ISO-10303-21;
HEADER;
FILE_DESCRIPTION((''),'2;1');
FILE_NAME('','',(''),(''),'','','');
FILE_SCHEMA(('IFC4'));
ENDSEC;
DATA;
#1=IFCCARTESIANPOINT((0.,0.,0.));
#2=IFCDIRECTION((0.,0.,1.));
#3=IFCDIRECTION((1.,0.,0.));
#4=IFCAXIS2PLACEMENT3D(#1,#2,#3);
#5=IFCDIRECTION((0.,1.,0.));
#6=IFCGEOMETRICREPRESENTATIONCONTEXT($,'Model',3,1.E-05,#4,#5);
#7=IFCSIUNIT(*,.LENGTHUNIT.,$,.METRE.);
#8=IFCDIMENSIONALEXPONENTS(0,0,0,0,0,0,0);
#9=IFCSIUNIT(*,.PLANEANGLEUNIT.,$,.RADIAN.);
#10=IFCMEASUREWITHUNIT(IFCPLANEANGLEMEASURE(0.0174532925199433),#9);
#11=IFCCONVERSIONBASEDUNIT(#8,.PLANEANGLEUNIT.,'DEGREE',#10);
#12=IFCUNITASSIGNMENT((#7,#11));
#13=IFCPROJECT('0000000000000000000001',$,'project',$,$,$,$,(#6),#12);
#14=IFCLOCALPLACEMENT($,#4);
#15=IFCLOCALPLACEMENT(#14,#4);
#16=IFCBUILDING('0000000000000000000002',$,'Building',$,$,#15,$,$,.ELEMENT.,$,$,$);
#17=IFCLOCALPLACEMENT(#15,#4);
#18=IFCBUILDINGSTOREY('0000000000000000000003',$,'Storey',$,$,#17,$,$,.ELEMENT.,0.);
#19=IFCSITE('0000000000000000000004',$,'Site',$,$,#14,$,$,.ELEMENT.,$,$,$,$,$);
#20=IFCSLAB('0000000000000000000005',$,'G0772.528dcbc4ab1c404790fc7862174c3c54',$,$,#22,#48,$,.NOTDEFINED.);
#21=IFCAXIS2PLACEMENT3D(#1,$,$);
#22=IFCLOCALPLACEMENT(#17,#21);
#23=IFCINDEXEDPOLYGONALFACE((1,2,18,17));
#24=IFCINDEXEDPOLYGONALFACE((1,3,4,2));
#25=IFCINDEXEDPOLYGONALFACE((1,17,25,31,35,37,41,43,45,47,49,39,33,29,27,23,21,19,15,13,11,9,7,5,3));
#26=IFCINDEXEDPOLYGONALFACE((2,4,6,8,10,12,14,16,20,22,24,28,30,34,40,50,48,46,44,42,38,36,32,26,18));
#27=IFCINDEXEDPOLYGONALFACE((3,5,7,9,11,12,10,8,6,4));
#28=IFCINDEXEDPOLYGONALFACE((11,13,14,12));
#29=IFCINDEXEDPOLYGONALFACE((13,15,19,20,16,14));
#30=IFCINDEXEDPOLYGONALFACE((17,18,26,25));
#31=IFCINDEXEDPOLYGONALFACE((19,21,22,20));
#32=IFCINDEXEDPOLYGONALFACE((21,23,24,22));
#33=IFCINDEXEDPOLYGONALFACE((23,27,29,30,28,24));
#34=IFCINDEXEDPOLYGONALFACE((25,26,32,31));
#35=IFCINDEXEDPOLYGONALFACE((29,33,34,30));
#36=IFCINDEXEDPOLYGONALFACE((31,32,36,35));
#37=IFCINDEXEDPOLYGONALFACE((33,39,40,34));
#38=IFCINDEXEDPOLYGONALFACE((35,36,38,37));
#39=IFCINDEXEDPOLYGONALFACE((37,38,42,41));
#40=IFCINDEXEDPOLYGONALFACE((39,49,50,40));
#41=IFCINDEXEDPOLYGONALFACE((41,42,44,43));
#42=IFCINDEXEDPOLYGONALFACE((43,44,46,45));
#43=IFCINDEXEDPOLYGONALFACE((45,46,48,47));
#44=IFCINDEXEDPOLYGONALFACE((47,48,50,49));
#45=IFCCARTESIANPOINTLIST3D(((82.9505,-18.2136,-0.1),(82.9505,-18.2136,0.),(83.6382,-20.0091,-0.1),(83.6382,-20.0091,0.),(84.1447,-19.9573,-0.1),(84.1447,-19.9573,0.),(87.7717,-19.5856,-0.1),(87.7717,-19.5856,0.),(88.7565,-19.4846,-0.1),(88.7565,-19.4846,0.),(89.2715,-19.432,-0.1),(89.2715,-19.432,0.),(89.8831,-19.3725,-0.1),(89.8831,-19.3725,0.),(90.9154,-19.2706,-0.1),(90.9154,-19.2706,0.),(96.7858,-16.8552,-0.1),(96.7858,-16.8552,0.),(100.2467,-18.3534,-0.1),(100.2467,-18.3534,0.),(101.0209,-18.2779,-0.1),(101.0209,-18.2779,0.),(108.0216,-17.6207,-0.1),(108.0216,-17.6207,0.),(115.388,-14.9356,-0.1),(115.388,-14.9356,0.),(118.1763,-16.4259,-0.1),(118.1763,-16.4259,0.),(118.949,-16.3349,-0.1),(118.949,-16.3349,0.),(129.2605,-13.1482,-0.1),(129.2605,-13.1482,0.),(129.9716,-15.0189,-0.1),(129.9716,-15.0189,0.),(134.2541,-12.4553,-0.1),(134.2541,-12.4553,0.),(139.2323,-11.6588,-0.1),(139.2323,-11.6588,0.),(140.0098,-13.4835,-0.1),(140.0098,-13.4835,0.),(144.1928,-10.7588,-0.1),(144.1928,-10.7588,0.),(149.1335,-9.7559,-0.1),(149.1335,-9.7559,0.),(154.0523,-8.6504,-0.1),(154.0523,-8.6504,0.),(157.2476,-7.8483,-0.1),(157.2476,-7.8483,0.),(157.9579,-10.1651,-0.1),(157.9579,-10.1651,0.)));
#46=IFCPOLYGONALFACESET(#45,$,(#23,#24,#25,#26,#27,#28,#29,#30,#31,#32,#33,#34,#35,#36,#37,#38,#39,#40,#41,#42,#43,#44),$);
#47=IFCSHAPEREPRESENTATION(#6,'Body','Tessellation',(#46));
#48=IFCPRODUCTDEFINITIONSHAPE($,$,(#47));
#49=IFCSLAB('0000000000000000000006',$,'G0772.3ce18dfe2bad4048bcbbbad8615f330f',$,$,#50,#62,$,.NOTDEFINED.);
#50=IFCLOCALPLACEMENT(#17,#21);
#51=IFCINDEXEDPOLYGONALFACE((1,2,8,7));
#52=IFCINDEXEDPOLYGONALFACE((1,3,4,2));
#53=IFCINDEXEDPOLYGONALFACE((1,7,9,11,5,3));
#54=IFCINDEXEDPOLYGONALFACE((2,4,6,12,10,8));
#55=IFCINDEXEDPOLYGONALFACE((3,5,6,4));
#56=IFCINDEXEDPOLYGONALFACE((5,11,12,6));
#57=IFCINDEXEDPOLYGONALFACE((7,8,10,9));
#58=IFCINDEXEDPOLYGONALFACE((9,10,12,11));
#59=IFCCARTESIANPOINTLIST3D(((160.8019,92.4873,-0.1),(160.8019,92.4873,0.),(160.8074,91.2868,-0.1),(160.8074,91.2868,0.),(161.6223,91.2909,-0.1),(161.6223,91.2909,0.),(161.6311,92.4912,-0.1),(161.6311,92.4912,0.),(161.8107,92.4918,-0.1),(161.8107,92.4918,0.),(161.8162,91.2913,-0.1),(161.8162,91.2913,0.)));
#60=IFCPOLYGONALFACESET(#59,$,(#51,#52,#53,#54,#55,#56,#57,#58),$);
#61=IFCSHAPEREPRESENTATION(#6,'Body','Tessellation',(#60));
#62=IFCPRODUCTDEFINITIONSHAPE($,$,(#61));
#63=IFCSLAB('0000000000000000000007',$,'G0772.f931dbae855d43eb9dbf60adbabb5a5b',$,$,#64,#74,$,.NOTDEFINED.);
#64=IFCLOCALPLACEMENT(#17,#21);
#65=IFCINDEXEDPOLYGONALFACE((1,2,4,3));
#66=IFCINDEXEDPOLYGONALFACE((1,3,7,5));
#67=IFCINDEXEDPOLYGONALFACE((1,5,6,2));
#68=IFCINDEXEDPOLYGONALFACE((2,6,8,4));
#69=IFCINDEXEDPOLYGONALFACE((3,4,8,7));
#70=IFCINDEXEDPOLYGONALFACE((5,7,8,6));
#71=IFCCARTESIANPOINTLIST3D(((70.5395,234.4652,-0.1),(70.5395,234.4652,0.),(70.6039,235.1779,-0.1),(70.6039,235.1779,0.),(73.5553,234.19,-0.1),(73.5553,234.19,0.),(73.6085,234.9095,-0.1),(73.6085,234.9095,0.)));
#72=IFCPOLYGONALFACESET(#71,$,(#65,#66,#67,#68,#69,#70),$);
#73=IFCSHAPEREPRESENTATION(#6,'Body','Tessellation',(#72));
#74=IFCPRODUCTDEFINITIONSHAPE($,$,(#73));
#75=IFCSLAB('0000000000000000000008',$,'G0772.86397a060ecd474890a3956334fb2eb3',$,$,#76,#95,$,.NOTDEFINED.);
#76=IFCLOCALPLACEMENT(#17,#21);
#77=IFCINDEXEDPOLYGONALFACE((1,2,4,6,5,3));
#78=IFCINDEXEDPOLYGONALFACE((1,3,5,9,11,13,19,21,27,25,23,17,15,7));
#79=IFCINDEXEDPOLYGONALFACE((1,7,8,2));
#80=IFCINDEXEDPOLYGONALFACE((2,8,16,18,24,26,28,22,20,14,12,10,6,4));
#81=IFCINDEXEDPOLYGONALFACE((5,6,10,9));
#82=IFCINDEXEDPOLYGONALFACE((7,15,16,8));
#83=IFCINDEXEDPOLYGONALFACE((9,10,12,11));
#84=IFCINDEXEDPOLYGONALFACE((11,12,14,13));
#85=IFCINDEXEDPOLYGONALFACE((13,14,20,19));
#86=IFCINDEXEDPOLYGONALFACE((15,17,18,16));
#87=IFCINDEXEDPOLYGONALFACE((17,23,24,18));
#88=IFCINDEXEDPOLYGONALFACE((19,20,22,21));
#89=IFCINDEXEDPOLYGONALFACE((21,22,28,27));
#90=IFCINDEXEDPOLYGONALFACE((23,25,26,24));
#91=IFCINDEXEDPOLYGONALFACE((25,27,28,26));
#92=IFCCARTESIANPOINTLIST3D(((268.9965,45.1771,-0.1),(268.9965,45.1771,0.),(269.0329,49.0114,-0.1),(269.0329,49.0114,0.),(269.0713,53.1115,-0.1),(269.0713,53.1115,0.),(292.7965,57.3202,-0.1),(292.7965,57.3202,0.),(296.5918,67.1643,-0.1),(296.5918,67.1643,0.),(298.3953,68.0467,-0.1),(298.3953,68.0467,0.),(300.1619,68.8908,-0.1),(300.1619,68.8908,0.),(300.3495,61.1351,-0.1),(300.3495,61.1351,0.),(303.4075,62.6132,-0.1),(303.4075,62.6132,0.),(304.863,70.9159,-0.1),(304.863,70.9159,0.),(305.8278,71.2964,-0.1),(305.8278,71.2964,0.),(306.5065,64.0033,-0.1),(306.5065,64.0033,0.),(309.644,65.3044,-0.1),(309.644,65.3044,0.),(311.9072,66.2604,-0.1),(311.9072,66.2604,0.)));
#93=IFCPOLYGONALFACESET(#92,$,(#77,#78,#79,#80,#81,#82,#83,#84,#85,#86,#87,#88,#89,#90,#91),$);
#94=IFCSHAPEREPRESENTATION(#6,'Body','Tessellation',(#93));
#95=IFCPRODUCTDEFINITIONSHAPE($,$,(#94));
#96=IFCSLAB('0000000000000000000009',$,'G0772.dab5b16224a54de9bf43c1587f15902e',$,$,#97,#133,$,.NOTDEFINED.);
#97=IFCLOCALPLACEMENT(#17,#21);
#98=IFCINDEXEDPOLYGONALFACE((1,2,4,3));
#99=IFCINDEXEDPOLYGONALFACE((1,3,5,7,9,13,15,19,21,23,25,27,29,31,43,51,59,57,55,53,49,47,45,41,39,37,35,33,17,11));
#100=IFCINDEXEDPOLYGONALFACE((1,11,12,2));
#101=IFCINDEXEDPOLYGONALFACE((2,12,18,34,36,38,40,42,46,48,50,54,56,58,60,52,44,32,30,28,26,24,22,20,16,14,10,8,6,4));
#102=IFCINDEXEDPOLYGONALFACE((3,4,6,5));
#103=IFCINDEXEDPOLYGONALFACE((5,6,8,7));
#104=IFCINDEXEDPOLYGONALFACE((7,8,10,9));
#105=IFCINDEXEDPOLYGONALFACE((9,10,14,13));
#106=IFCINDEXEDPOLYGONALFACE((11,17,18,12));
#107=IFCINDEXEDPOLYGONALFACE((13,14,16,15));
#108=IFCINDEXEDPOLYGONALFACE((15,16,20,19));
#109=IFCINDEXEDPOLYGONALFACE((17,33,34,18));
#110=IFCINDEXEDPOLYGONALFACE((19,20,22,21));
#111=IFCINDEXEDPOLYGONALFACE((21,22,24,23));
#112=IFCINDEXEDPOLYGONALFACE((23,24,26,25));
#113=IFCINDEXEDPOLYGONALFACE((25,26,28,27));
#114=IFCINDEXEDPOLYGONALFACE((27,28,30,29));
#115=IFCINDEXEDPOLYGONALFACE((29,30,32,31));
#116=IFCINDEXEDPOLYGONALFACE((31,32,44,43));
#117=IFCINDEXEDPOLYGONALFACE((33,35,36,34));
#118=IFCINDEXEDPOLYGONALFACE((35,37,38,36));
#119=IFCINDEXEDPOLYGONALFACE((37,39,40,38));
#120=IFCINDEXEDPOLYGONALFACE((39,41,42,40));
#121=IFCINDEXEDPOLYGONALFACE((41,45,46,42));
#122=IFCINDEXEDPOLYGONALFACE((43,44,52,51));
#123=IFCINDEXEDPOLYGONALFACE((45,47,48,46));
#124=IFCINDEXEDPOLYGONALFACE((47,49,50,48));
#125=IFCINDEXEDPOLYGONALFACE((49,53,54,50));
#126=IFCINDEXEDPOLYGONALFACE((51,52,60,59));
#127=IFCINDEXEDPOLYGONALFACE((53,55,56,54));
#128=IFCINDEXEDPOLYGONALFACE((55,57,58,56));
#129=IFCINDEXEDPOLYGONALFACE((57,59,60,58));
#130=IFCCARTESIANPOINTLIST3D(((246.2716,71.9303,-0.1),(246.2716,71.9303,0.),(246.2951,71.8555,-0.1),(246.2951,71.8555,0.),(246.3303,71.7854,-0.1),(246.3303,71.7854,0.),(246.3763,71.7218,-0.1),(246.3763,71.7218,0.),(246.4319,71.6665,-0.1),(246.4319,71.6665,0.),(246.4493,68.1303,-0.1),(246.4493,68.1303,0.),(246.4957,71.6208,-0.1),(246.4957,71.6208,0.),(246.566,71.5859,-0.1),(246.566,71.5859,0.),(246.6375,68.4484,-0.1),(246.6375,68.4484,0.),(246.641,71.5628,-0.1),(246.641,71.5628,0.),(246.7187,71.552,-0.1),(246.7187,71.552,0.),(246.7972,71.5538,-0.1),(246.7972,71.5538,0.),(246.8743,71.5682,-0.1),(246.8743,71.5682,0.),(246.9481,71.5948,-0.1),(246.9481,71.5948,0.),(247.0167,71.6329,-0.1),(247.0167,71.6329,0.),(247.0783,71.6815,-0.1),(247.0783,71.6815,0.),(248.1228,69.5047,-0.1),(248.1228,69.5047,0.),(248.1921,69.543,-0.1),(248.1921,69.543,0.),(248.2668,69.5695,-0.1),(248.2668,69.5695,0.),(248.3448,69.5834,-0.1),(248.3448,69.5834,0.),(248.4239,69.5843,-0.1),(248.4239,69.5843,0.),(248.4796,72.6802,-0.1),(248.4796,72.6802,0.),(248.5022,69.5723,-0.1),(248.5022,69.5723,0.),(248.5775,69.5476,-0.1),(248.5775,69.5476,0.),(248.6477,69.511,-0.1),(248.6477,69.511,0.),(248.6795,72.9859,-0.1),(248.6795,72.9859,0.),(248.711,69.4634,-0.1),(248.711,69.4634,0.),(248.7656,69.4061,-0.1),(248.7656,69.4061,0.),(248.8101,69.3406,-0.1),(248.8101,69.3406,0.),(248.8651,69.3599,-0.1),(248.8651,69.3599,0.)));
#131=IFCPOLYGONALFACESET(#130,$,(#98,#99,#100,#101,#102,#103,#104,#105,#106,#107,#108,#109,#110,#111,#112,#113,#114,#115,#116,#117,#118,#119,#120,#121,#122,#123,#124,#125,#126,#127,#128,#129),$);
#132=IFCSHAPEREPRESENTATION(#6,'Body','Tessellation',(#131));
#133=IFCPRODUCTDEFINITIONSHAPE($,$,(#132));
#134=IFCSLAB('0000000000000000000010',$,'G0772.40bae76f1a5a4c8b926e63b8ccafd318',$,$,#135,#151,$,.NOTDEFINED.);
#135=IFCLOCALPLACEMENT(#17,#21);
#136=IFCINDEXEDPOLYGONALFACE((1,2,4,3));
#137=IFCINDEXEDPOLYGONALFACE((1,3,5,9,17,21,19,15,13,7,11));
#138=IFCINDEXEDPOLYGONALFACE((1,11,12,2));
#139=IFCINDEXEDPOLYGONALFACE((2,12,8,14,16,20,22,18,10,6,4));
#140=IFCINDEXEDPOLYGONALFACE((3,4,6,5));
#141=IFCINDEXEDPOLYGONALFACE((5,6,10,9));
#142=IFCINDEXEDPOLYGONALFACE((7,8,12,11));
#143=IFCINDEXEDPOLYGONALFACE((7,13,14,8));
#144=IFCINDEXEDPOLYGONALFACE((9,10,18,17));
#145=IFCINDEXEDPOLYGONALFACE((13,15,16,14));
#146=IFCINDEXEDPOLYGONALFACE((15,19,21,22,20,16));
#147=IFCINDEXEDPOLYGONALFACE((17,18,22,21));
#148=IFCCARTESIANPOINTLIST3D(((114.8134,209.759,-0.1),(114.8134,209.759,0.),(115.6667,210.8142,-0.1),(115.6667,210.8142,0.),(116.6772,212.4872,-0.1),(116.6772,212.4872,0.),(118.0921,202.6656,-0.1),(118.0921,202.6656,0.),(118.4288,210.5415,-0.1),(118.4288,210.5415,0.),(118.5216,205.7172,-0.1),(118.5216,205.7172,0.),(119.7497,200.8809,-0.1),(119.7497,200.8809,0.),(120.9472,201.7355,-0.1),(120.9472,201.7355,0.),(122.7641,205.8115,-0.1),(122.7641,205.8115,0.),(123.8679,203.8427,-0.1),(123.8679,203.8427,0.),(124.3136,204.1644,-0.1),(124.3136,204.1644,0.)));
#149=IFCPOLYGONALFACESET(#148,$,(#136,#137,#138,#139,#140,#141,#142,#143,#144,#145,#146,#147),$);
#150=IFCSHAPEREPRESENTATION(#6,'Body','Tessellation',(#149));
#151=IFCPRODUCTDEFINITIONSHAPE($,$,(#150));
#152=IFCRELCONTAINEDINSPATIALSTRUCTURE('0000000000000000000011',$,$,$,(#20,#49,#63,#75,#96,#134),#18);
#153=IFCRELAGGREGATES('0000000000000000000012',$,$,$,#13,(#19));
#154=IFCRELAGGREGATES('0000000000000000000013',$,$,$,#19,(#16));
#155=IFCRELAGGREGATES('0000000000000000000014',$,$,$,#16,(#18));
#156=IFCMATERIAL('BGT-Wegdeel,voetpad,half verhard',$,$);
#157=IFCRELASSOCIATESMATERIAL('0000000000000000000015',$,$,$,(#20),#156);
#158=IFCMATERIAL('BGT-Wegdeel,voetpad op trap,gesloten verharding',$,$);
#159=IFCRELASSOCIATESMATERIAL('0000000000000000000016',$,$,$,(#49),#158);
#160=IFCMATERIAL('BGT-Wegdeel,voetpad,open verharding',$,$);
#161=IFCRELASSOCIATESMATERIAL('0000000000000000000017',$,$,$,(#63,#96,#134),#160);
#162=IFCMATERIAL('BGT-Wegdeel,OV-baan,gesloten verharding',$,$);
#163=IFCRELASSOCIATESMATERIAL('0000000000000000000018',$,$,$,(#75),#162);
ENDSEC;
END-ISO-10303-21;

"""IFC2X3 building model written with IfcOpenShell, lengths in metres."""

from ifc_helpers import new_model, entity, si_unit, converted_unit, direction, frame, origin_with_axes, place, context, project, spatial, polyline, outline, extrude, material, element, save


model = new_model("IFC2X3")

# Units and contexts
model_context = context("Model", 3, precision=1e-05, world=origin_with_axes(), true_north=direction((0.0, 1.0, 0.0)))
ifc_project = project(units=[si_unit("LENGTHUNIT", "METRE"), converted_unit("PLANEANGLEUNIT", "DEGREE", entity("IfcPlaneAngleMeasure", 0.0174532925199433), si_unit("PLANEANGLEUNIT", "RADIAN"), dimensions=[0, 0, 0, 0, 0, 0, 0])], contexts=[model_context])

# Site, building, storey
site_placement = place(None, origin_with_axes())
site = spatial("IfcSite", under=ifc_project, at=site_placement, Name="Site", CompositionType="ELEMENT")
building_placement = place(site_placement, origin_with_axes())
building = spatial("IfcBuilding", under=site, at=building_placement, Name="Building", CompositionType="ELEMENT")
storey_placement = place(building_placement, origin_with_axes())
storey = spatial("IfcBuildingStorey", under=building, at=storey_placement, Name="Storey", CompositionType="ELEMENT", Elevation=0.0)

# Slabs
ifc_material_1 = material(Name="BGT-Wegdeel,voetpad,half verhard")
ifc_material_2 = material(Name="BGT-Wegdeel,voetpad,open verharding")
ifc_material_3 = material(Name="BGT-Wegdeel,OV-baan,gesloten verharding")
slab_1_placement = place(storey_placement, frame((0.0, 0.0, -0.1), z_axis=(0.0, 0.0, 1.0), x_axis=(1.0, 0.0, 0.0)))
element("IfcSlab", 1, at=slab_1_placement, inside=storey, material=ifc_material_1, Name="G0772.528dcbc4ab1c404790fc7862174c3c54", PredefinedType="NOTDEFINED", context=model_context, shape_type="SweptSolid", body=[
    extrude(outline(polyline([(96.7858, -16.8552), (115.388, -14.9356), (129.2605, -13.1482), (134.2541, -12.4553), (139.2323, -11.6588), (144.1928, -10.7588), (149.1335, -9.7559), (154.0523, -8.6504), (157.2476, -7.8483), (157.9579, -10.1651), (140.0098, -13.4835), (129.9716, -15.0189), (118.949, -16.3349), (118.1763, -16.4259), (108.0216, -17.6207), (101.0209, -18.2779), (100.2467, -18.3534), (90.9154, -19.2706), (89.8831, -19.3725), (89.2715, -19.432), (88.7565, -19.4846), (87.7717, -19.5856), (84.1447, -19.9573), (83.6382, -20.0091), (82.9505, -18.2136), (96.7858, -16.8552)])), origin_with_axes(), (0.0, 0.0, 1.0), 0.1),
])
ifc_material_4 = material(Name="BGT-Wegdeel,voetpad op trap,gesloten verharding")
slab_2_placement = place(storey_placement, frame((0.0, 0.0, -0.1), z_axis=(0.0, 0.0, 1.0), x_axis=(1.0, 0.0, 0.0)))
element("IfcSlab", 2, at=slab_2_placement, inside=storey, material=ifc_material_4, Name="G0772.3ce18dfe2bad4048bcbbbad8615f330f", PredefinedType="NOTDEFINED", context=model_context, shape_type="SweptSolid", body=[
    extrude(outline(polyline([(161.6311, 92.4912), (161.8107, 92.4918), (161.8162, 91.2913), (161.6223, 91.2909), (160.8074, 91.2868), (160.8019, 92.4873), (161.6311, 92.4912)])), origin_with_axes(), (0.0, 0.0, 1.0), 0.1),
])
slab_3_placement = place(storey_placement, frame((0.0, 0.0, -0.1), z_axis=(0.0, 0.0, 1.0), x_axis=(1.0, 0.0, 0.0)))
element("IfcSlab", 3, at=slab_3_placement, inside=storey, material=ifc_material_2, Name="G0772.f931dbae855d43eb9dbf60adbabb5a5b", PredefinedType="NOTDEFINED", context=model_context, shape_type="SweptSolid", body=[
    extrude(outline(polyline([(73.6085, 234.9095), (73.5553, 234.19), (70.5395, 234.4652), (70.6039, 235.1779), (73.6085, 234.9095)])), origin_with_axes(), (0.0, 0.0, 1.0), 0.1),
])
slab_4_placement = place(storey_placement, frame((0.0, 0.0, -0.1), z_axis=(0.0, 0.0, 1.0), x_axis=(1.0, 0.0, 0.0)))
element("IfcSlab", 4, at=slab_4_placement, inside=storey, material=ifc_material_3, Name="G0772.86397a060ecd474890a3956334fb2eb3", PredefinedType="NOTDEFINED", context=model_context, shape_type="SweptSolid", body=[
    extrude(outline(polyline([(309.644, 65.3044), (306.5065, 64.0033), (303.4075, 62.6132), (300.3495, 61.1351), (292.7965, 57.3202), (268.9965, 45.1771), (269.0329, 49.0114), (269.0713, 53.1115), (296.5918, 67.1643), (298.3953, 68.0467), (300.1619, 68.8908), (304.863, 70.9159), (305.8278, 71.2964), (311.9072, 66.2604), (309.644, 65.3044)])), origin_with_axes(), (0.0, 0.0, 1.0), 0.1),
])
slab_5_placement = place(storey_placement, frame((0.0, 0.0, -0.1), z_axis=(0.0, 0.0, 1.0), x_axis=(1.0, 0.0, 0.0)))
element("IfcSlab", 5, at=slab_5_placement, inside=storey, material=ifc_material_2, Name="G0772.dab5b16224a54de9bf43c1587f15902e", PredefinedType="NOTDEFINED", context=model_context, shape_type="SweptSolid", body=[
    extrude(outline(polyline([(246.2951, 71.8555), (246.3303, 71.7854), (246.3763, 71.7218), (246.4319, 71.6665), (246.4957, 71.6208), (246.566, 71.5859), (246.641, 71.5628), (246.7187, 71.552), (246.7972, 71.5538), (246.8743, 71.5682), (246.9481, 71.5948), (247.0167, 71.6329), (247.0783, 71.6815), (248.4796, 72.6802), (248.6795, 72.9859), (248.8651, 69.3599), (248.8101, 69.3406), (248.7656, 69.4061), (248.711, 69.4634), (248.6477, 69.511), (248.5775, 69.5476), (248.5022, 69.5723), (248.4239, 69.5843), (248.3448, 69.5834), (248.2668, 69.5695), (248.1921, 69.543), (248.1228, 69.5047), (246.6375, 68.4484), (246.4493, 68.1303), (246.2716, 71.9303), (246.2951, 71.8555)])), origin_with_axes(), (0.0, 0.0, 1.0), 0.1),
])
slab_6_placement = place(storey_placement, frame((0.0, 0.0, -0.1), z_axis=(0.0, 0.0, 1.0), x_axis=(1.0, 0.0, 0.0)))
element("IfcSlab", 6, at=slab_6_placement, inside=storey, material=ifc_material_2, Name="G0772.40bae76f1a5a4c8b926e63b8ccafd318", PredefinedType="NOTDEFINED", context=model_context, shape_type="SweptSolid", body=[
    extrude(outline(polyline([(122.7641, 205.8115), (124.3136, 204.1644), (123.8679, 203.8427), (120.9472, 201.7355), (119.7497, 200.8809), (118.0921, 202.6656), (118.5216, 205.7172), (114.8134, 209.759), (115.6667, 210.8142), (116.6772, 212.4872), (118.4288, 210.5415), (122.7641, 205.8115)])), origin_with_axes(), (0.0, 0.0, 1.0), 0.1),
])

save(model, "model.ifc")
